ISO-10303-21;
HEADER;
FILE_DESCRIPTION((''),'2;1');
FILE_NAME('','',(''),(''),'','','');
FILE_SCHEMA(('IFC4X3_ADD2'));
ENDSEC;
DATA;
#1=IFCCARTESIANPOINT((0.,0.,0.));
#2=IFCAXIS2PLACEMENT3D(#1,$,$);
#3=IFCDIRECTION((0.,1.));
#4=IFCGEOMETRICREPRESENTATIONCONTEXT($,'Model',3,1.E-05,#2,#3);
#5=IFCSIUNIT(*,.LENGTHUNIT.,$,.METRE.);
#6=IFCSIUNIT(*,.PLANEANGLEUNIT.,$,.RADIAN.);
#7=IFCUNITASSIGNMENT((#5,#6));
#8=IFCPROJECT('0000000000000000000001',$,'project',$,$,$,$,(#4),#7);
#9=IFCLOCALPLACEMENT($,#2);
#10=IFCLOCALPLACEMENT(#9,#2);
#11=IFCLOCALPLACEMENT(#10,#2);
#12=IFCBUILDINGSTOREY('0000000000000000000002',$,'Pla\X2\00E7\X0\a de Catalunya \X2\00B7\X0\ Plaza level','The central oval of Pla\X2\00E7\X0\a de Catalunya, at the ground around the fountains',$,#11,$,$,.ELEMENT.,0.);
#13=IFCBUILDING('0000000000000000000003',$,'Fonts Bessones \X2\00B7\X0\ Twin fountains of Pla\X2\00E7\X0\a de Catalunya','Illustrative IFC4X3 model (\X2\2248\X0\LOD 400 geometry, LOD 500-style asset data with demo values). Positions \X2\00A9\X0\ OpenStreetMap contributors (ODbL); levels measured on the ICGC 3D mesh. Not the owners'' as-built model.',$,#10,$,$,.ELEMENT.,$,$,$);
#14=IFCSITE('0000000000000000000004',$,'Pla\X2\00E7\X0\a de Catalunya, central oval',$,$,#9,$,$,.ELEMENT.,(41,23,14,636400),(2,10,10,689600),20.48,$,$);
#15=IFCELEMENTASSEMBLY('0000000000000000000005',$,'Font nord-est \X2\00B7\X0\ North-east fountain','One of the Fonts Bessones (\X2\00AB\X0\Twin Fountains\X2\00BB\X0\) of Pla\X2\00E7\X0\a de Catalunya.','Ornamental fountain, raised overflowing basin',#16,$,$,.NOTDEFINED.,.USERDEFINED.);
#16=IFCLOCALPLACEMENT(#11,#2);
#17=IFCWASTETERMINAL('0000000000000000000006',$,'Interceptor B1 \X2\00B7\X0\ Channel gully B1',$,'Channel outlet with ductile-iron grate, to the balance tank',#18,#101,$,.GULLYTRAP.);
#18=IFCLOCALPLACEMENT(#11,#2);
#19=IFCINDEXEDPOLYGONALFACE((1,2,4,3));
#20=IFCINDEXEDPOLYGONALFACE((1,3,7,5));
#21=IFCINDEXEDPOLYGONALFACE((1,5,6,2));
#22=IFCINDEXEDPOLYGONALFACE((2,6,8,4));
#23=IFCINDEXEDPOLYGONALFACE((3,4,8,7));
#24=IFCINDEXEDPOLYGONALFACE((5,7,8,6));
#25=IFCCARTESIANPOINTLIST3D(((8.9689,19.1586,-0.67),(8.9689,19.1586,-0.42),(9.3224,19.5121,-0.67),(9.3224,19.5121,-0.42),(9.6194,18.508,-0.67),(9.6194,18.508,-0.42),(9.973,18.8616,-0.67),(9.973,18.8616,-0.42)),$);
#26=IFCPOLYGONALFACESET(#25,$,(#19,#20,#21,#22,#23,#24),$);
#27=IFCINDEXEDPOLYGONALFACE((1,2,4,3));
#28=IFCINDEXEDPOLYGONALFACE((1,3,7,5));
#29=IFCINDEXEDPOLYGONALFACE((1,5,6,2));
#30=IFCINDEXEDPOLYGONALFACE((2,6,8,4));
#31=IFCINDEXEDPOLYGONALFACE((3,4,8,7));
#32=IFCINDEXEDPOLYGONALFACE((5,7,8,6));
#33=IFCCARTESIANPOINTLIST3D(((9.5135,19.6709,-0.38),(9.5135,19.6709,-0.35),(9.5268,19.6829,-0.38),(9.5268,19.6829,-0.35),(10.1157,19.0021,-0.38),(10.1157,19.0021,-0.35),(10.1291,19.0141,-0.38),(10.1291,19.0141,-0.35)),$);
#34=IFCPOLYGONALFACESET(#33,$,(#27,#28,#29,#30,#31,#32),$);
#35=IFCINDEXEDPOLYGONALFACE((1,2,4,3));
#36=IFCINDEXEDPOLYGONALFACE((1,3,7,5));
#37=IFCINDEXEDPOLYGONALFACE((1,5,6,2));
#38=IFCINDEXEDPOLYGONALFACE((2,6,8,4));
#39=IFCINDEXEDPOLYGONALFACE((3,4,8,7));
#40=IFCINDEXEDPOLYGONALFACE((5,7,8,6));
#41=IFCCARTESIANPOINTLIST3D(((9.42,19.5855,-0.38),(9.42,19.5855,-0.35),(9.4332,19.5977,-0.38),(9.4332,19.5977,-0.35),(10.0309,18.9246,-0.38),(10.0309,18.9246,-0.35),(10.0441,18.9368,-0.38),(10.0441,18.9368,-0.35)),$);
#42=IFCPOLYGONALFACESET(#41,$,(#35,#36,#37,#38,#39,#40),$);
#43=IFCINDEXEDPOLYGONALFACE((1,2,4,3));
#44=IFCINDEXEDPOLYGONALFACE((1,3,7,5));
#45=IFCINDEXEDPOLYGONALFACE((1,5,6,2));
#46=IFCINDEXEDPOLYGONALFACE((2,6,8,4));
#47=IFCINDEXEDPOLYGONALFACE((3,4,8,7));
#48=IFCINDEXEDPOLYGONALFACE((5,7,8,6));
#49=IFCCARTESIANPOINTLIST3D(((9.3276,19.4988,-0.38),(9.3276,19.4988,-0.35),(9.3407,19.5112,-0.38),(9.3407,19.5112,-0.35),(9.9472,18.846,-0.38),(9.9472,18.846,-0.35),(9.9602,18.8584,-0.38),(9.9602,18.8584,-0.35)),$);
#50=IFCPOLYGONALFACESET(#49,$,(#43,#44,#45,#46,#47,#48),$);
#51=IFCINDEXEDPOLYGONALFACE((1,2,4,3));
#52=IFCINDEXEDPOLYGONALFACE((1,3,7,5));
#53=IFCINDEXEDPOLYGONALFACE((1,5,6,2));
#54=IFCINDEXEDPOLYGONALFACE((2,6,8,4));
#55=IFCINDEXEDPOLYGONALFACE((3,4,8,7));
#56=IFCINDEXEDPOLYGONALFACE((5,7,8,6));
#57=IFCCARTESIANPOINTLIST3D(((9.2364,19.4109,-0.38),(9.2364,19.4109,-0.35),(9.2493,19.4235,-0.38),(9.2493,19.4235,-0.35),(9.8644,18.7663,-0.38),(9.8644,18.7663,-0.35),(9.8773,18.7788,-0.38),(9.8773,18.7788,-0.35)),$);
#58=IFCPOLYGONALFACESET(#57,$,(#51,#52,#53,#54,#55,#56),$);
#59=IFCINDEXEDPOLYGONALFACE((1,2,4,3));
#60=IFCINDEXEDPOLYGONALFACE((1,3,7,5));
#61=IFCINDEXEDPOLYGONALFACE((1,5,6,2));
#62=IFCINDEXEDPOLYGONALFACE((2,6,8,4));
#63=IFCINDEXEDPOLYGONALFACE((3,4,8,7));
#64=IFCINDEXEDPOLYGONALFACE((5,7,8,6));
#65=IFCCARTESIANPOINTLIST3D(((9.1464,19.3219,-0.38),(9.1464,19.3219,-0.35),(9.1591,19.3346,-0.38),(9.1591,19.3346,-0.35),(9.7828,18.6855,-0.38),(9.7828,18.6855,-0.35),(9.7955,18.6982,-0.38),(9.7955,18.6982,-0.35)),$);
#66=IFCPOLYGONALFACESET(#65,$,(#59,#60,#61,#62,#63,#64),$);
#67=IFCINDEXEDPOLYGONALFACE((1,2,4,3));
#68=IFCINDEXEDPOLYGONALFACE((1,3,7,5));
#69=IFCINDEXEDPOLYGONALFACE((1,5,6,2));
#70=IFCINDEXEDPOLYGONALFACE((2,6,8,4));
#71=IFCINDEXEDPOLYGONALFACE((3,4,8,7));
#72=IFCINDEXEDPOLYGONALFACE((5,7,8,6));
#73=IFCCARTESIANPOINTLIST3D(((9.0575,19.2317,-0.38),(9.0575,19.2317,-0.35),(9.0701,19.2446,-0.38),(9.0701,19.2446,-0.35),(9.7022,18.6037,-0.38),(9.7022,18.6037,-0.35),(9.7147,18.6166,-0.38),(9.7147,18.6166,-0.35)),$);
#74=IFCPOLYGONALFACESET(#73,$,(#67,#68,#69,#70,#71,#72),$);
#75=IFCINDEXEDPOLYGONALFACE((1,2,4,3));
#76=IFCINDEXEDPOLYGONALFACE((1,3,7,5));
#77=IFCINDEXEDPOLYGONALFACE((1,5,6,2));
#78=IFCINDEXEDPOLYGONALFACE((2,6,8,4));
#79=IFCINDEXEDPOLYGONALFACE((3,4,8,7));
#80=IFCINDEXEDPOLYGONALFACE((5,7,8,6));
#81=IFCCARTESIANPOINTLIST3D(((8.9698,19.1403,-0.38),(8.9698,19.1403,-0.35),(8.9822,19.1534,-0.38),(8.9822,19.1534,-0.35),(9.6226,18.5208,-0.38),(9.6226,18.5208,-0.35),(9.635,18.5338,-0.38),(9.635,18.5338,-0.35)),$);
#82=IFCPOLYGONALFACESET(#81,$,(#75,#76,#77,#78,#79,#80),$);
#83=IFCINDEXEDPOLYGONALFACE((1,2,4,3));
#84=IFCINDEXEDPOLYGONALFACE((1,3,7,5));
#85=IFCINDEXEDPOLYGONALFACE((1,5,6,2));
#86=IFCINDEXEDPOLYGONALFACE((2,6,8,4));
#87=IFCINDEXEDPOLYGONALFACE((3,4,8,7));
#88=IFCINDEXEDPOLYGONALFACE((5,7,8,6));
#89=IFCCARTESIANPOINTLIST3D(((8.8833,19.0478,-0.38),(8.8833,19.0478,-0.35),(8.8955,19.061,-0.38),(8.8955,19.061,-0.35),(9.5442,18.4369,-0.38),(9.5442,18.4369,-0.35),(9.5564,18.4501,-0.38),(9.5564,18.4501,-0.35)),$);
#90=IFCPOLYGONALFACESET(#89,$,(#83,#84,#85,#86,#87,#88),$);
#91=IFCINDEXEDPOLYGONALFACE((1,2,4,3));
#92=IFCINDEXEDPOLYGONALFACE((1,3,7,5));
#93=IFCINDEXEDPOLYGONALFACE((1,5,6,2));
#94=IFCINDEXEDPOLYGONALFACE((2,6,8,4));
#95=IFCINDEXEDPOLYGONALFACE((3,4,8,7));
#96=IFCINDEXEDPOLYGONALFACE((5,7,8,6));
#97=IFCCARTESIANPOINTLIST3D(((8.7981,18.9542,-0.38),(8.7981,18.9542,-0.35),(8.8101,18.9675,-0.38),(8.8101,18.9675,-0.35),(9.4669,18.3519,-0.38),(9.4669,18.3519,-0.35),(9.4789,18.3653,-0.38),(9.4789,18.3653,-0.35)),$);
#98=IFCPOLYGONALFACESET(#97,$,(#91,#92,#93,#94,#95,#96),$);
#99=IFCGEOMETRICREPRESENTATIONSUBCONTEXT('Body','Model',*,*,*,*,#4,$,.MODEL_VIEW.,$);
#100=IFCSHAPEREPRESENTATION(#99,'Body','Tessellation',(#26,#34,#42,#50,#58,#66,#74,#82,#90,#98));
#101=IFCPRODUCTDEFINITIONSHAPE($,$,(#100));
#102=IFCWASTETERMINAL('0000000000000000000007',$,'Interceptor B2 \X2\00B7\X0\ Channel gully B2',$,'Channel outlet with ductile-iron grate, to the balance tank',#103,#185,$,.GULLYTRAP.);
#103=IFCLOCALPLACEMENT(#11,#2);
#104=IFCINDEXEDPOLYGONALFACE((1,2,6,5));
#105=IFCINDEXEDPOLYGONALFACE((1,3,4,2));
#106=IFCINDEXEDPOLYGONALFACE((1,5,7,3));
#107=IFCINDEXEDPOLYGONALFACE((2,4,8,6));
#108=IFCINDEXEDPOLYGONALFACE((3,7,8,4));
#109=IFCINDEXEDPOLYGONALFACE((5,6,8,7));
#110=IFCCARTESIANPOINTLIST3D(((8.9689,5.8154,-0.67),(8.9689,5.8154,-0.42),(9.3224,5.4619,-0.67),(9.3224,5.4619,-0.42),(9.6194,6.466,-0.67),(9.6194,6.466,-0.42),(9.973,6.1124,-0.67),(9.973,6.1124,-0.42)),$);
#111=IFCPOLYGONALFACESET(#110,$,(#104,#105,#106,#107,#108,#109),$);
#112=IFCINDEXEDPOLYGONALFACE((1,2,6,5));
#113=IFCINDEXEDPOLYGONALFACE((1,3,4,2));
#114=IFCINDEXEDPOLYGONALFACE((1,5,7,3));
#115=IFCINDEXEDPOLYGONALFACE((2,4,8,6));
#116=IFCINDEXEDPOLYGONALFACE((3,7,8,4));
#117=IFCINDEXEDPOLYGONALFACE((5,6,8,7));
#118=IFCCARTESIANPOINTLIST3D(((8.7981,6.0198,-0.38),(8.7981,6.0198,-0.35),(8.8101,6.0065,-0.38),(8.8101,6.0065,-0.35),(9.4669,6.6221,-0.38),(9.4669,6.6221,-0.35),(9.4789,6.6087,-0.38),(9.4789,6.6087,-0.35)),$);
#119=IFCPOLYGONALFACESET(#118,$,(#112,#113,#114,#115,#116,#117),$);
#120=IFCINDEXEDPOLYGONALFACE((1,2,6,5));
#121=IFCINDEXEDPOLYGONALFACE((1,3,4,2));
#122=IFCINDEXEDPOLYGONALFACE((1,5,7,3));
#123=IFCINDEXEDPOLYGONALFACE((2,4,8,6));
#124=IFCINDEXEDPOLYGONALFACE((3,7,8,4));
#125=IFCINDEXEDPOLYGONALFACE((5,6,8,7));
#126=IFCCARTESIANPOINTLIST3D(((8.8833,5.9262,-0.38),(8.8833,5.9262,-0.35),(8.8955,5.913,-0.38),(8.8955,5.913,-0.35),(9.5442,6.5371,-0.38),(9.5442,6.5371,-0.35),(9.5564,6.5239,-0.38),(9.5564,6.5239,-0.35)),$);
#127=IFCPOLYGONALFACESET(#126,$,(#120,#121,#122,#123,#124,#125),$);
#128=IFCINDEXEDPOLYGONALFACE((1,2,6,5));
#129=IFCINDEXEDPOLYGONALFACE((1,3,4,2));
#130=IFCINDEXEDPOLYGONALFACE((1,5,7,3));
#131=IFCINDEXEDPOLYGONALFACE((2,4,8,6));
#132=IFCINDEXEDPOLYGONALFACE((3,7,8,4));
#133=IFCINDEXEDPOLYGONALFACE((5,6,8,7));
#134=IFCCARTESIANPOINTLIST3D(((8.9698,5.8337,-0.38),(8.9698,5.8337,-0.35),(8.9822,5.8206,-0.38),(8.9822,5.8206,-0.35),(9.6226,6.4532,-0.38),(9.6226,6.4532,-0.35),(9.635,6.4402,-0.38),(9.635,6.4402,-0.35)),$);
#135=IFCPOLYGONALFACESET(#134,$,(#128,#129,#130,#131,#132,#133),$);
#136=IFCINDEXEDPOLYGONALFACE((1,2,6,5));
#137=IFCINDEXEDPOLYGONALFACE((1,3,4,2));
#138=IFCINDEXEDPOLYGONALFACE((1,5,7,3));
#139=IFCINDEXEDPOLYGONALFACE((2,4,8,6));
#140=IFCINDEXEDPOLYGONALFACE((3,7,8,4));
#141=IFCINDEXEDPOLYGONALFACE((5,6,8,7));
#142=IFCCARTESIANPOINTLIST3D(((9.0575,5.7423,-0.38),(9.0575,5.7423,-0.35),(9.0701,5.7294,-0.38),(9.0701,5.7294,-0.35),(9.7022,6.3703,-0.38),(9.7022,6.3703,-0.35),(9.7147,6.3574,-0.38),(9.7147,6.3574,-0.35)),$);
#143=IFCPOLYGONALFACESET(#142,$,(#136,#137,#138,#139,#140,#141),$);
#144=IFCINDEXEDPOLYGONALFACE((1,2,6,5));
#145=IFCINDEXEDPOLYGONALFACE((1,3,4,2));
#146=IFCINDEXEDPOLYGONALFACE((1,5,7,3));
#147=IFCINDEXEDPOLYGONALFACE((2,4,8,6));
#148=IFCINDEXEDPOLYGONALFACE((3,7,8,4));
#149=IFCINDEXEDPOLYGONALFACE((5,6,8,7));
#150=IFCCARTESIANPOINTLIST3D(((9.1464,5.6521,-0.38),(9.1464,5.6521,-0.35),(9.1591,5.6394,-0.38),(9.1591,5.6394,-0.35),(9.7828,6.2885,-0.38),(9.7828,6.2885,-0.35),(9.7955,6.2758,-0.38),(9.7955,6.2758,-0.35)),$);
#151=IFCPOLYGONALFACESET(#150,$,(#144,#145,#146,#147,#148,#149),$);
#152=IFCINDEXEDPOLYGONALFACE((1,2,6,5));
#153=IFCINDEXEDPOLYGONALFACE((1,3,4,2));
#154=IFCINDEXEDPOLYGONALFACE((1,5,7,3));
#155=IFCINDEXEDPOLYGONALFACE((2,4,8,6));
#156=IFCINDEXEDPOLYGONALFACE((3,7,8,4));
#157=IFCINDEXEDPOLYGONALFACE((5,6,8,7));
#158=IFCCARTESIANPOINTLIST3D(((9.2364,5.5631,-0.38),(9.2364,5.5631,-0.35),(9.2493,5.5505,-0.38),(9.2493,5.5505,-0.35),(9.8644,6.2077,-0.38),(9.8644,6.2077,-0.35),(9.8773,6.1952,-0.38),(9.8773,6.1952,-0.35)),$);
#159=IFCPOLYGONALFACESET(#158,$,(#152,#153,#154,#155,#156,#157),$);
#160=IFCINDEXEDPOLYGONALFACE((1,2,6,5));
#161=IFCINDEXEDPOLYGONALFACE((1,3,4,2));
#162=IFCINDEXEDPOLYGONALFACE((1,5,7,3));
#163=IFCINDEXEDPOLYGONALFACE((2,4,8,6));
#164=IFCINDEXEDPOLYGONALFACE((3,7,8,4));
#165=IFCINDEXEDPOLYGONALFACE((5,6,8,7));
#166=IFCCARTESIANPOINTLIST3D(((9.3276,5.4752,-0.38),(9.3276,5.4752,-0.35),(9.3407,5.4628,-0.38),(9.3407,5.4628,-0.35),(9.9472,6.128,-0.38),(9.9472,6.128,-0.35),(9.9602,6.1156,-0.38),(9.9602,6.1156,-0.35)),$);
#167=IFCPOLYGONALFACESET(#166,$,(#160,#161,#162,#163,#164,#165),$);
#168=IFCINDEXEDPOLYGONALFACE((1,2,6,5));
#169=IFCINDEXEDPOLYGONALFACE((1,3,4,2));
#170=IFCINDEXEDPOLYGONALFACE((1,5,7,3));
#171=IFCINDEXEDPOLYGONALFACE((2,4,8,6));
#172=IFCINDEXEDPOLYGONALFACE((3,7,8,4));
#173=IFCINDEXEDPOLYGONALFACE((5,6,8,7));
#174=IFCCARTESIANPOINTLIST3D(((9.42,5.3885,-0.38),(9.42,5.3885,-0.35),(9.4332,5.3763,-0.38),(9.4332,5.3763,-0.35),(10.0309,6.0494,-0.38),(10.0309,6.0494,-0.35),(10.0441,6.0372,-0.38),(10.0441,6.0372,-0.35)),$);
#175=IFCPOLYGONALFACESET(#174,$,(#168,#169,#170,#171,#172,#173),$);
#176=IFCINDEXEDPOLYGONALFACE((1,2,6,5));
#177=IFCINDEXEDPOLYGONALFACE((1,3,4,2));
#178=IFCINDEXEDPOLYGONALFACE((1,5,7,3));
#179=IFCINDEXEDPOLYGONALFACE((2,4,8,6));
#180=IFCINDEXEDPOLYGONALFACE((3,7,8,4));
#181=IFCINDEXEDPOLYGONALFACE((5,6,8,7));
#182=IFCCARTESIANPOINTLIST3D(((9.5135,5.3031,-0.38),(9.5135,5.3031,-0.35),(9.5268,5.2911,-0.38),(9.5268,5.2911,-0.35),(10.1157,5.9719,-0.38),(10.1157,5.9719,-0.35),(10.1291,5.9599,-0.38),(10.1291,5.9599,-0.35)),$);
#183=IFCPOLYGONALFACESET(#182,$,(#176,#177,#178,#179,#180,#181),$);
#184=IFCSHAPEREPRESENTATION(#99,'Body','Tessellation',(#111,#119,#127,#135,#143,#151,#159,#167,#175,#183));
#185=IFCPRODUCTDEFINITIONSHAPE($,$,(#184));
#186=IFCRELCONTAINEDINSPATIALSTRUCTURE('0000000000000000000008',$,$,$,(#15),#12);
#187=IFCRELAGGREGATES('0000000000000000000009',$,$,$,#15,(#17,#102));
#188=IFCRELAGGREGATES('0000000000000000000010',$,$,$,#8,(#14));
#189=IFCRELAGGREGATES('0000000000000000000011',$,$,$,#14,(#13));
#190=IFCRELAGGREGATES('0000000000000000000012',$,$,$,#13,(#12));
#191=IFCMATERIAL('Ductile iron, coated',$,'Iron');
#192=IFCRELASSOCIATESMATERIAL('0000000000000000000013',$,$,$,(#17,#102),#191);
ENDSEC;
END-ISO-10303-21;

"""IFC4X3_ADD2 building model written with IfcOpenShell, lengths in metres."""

from ifc_helpers import new_model, si_unit, direction, frame, frame_2d, origin, place, context, subcontext, project, spatial, rectangle, extrude, material, element, aggregate, save


model = new_model("IFC4X3_ADD2")

# Units and contexts
model_context = context("Model", 3, precision=1e-05, world=origin(), true_north=direction((0.0, 1.0)))
body_context = subcontext(model_context, "Body", "Model", "MODEL_VIEW")
ifc_project = project(units=[si_unit("LENGTHUNIT", "METRE"), si_unit("PLANEANGLEUNIT", "RADIAN")], contexts=[model_context])

# Site, building, storey
site_placement = place(None, origin())
site = spatial("IfcSite", under=ifc_project, at=site_placement, Name="Plaça de Catalunya, central oval", CompositionType="ELEMENT", RefLatitude=(41, 23, 14, 636400), RefLongitude=(2, 10, 10, 689600), RefElevation=20.48)
building_placement = place(site_placement, origin())
building = spatial("IfcBuilding", under=site, at=building_placement, Name="Fonts Bessones · Twin fountains of Plaça de Catalunya", Description="Illustrative IFC4X3 model (≈LOD 400 geometry, LOD 500-style asset data with demo values). Positions © OpenStreetMap contributors (ODbL); levels measured on the ICGC 3D mesh. Not the owners' as-built model.", CompositionType="ELEMENT")
storey_placement = place(building_placement, origin())
storey = spatial("IfcBuildingStorey", under=building, at=storey_placement, Name="Plaça de Catalunya · Plaza level", Description="The central oval of Plaça de Catalunya, at the ground around the fountains", CompositionType="ELEMENT", Elevation=0.0)

# Element assembly, waste terminals
assembly_1_placement = place(building_placement, origin())
assembly_1 = element("IfcElementAssembly", 1, at=assembly_1_placement, inside=storey, Name="Font nord-est · North-east fountain", Description="One of the Fonts Bessones («Twin Fountains») of Plaça de Catalunya.", ObjectType="Ornamental fountain, raised overflowing basin", AssemblyPlace="NOTDEFINED", PredefinedType="USERDEFINED")
ifc_material_1 = material(Name="Ductile iron, coated", Category="Iron")
waste_terminal_1_placement = place(building_placement, origin())
waste_terminal_1 = element("IfcWasteTerminal", 2, at=waste_terminal_1_placement, material=ifc_material_1, Name="Interceptor B1 · Channel gully B1", ObjectType="Channel outlet with ductile-iron grate, to the balance tank", PredefinedType="GULLYTRAP", context=body_context, shape_type="SweptSolid", body=[
    extrude(rectangle(XDim=0.92, YDim=0.5, at=frame_2d((0.0, 0.0), x_axis=(-0.707107, 0.707107))), frame((9.4709, 19.0101, -0.67)), (0.0, 0.0, 1.0), 0.25),
    extrude(rectangle(XDim=0.9, YDim=0.018, at=frame_2d((0.0, 0.0), x_axis=(-0.669131, 0.743145))), frame((9.8213, 19.3425, -0.38)), (0.0, 0.0, 1.0), 0.03),
    extrude(rectangle(XDim=0.9, YDim=0.018, at=frame_2d((0.0, 0.0), x_axis=(-0.678801, 0.734323))), frame((9.7321, 19.2611, -0.38)), (0.0, 0.0, 1.0), 0.03),
    extrude(rectangle(XDim=0.9, YDim=0.018, at=frame_2d((0.0, 0.0), x_axis=(-0.688355, 0.725374))), frame((9.6439, 19.1786, -0.38)), (0.0, 0.0, 1.0), 0.03),
    extrude(rectangle(XDim=0.9, YDim=0.018, at=frame_2d((0.0, 0.0), x_axis=(-0.69779, 0.716302))), frame((9.5569, 19.0949, -0.38)), (0.0, 0.0, 1.0), 0.03),
    extrude(rectangle(XDim=0.9, YDim=0.018, at=frame_2d((0.0, 0.0), x_axis=(-0.707107, 0.707107))), frame((9.4709, 19.0101, -0.38)), (0.0, 0.0, 1.0), 0.03),
    extrude(rectangle(XDim=0.9, YDim=0.018, at=frame_2d((0.0, 0.0), x_axis=(-0.716302, 0.69779))), frame((9.3861, 18.9241, -0.38)), (0.0, 0.0, 1.0), 0.03),
    extrude(rectangle(XDim=0.9, YDim=0.018, at=frame_2d((0.0, 0.0), x_axis=(-0.725374, 0.688355))), frame((9.3024, 18.8371, -0.38)), (0.0, 0.0, 1.0), 0.03),
    extrude(rectangle(XDim=0.9, YDim=0.018, at=frame_2d((0.0, 0.0), x_axis=(-0.734323, 0.678801))), frame((9.2199, 18.7489, -0.38)), (0.0, 0.0, 1.0), 0.03),
    extrude(rectangle(XDim=0.9, YDim=0.018, at=frame_2d((0.0, 0.0), x_axis=(-0.743145, 0.669131))), frame((9.1385, 18.6597, -0.38)), (0.0, 0.0, 1.0), 0.03),
])
waste_terminal_2_placement = place(building_placement, origin())
waste_terminal_2 = element("IfcWasteTerminal", 3, at=waste_terminal_2_placement, material=ifc_material_1, Name="Interceptor B2 · Channel gully B2", ObjectType="Channel outlet with ductile-iron grate, to the balance tank", PredefinedType="GULLYTRAP", context=body_context, shape_type="SweptSolid", body=[
    extrude(rectangle(XDim=0.92, YDim=0.5, at=frame_2d((0.0, 0.0), x_axis=(-0.707107, -0.707107))), frame((9.4709, 5.9639, -0.67)), (0.0, 0.0, 1.0), 0.25),
    extrude(rectangle(XDim=0.9, YDim=0.018, at=frame_2d((0.0, 0.0), x_axis=(-0.743145, -0.669131))), frame((9.1385, 6.3143, -0.38)), (0.0, 0.0, 1.0), 0.03),
    extrude(rectangle(XDim=0.9, YDim=0.018, at=frame_2d((0.0, 0.0), x_axis=(-0.734323, -0.678801))), frame((9.2199, 6.2251, -0.38)), (0.0, 0.0, 1.0), 0.03),
    extrude(rectangle(XDim=0.9, YDim=0.018, at=frame_2d((0.0, 0.0), x_axis=(-0.725374, -0.688355))), frame((9.3024, 6.1369, -0.38)), (0.0, 0.0, 1.0), 0.03),
    extrude(rectangle(XDim=0.9, YDim=0.018, at=frame_2d((0.0, 0.0), x_axis=(-0.716302, -0.69779))), frame((9.3861, 6.0499, -0.38)), (0.0, 0.0, 1.0), 0.03),
    extrude(rectangle(XDim=0.9, YDim=0.018, at=frame_2d((0.0, 0.0), x_axis=(-0.707107, -0.707107))), frame((9.4709, 5.9639, -0.38)), (0.0, 0.0, 1.0), 0.03),
    extrude(rectangle(XDim=0.9, YDim=0.018, at=frame_2d((0.0, 0.0), x_axis=(-0.69779, -0.716302))), frame((9.5569, 5.8791, -0.38)), (0.0, 0.0, 1.0), 0.03),
    extrude(rectangle(XDim=0.9, YDim=0.018, at=frame_2d((0.0, 0.0), x_axis=(-0.688355, -0.725374))), frame((9.6439, 5.7954, -0.38)), (0.0, 0.0, 1.0), 0.03),
    extrude(rectangle(XDim=0.9, YDim=0.018, at=frame_2d((0.0, 0.0), x_axis=(-0.678801, -0.734323))), frame((9.7321, 5.7129, -0.38)), (0.0, 0.0, 1.0), 0.03),
    extrude(rectangle(XDim=0.9, YDim=0.018, at=frame_2d((0.0, 0.0), x_axis=(-0.669131, -0.743145))), frame((9.8213, 5.6315, -0.38)), (0.0, 0.0, 1.0), 0.03),
])
aggregate(assembly_1, [waste_terminal_1, waste_terminal_2])

save(model, "model.ifc")
